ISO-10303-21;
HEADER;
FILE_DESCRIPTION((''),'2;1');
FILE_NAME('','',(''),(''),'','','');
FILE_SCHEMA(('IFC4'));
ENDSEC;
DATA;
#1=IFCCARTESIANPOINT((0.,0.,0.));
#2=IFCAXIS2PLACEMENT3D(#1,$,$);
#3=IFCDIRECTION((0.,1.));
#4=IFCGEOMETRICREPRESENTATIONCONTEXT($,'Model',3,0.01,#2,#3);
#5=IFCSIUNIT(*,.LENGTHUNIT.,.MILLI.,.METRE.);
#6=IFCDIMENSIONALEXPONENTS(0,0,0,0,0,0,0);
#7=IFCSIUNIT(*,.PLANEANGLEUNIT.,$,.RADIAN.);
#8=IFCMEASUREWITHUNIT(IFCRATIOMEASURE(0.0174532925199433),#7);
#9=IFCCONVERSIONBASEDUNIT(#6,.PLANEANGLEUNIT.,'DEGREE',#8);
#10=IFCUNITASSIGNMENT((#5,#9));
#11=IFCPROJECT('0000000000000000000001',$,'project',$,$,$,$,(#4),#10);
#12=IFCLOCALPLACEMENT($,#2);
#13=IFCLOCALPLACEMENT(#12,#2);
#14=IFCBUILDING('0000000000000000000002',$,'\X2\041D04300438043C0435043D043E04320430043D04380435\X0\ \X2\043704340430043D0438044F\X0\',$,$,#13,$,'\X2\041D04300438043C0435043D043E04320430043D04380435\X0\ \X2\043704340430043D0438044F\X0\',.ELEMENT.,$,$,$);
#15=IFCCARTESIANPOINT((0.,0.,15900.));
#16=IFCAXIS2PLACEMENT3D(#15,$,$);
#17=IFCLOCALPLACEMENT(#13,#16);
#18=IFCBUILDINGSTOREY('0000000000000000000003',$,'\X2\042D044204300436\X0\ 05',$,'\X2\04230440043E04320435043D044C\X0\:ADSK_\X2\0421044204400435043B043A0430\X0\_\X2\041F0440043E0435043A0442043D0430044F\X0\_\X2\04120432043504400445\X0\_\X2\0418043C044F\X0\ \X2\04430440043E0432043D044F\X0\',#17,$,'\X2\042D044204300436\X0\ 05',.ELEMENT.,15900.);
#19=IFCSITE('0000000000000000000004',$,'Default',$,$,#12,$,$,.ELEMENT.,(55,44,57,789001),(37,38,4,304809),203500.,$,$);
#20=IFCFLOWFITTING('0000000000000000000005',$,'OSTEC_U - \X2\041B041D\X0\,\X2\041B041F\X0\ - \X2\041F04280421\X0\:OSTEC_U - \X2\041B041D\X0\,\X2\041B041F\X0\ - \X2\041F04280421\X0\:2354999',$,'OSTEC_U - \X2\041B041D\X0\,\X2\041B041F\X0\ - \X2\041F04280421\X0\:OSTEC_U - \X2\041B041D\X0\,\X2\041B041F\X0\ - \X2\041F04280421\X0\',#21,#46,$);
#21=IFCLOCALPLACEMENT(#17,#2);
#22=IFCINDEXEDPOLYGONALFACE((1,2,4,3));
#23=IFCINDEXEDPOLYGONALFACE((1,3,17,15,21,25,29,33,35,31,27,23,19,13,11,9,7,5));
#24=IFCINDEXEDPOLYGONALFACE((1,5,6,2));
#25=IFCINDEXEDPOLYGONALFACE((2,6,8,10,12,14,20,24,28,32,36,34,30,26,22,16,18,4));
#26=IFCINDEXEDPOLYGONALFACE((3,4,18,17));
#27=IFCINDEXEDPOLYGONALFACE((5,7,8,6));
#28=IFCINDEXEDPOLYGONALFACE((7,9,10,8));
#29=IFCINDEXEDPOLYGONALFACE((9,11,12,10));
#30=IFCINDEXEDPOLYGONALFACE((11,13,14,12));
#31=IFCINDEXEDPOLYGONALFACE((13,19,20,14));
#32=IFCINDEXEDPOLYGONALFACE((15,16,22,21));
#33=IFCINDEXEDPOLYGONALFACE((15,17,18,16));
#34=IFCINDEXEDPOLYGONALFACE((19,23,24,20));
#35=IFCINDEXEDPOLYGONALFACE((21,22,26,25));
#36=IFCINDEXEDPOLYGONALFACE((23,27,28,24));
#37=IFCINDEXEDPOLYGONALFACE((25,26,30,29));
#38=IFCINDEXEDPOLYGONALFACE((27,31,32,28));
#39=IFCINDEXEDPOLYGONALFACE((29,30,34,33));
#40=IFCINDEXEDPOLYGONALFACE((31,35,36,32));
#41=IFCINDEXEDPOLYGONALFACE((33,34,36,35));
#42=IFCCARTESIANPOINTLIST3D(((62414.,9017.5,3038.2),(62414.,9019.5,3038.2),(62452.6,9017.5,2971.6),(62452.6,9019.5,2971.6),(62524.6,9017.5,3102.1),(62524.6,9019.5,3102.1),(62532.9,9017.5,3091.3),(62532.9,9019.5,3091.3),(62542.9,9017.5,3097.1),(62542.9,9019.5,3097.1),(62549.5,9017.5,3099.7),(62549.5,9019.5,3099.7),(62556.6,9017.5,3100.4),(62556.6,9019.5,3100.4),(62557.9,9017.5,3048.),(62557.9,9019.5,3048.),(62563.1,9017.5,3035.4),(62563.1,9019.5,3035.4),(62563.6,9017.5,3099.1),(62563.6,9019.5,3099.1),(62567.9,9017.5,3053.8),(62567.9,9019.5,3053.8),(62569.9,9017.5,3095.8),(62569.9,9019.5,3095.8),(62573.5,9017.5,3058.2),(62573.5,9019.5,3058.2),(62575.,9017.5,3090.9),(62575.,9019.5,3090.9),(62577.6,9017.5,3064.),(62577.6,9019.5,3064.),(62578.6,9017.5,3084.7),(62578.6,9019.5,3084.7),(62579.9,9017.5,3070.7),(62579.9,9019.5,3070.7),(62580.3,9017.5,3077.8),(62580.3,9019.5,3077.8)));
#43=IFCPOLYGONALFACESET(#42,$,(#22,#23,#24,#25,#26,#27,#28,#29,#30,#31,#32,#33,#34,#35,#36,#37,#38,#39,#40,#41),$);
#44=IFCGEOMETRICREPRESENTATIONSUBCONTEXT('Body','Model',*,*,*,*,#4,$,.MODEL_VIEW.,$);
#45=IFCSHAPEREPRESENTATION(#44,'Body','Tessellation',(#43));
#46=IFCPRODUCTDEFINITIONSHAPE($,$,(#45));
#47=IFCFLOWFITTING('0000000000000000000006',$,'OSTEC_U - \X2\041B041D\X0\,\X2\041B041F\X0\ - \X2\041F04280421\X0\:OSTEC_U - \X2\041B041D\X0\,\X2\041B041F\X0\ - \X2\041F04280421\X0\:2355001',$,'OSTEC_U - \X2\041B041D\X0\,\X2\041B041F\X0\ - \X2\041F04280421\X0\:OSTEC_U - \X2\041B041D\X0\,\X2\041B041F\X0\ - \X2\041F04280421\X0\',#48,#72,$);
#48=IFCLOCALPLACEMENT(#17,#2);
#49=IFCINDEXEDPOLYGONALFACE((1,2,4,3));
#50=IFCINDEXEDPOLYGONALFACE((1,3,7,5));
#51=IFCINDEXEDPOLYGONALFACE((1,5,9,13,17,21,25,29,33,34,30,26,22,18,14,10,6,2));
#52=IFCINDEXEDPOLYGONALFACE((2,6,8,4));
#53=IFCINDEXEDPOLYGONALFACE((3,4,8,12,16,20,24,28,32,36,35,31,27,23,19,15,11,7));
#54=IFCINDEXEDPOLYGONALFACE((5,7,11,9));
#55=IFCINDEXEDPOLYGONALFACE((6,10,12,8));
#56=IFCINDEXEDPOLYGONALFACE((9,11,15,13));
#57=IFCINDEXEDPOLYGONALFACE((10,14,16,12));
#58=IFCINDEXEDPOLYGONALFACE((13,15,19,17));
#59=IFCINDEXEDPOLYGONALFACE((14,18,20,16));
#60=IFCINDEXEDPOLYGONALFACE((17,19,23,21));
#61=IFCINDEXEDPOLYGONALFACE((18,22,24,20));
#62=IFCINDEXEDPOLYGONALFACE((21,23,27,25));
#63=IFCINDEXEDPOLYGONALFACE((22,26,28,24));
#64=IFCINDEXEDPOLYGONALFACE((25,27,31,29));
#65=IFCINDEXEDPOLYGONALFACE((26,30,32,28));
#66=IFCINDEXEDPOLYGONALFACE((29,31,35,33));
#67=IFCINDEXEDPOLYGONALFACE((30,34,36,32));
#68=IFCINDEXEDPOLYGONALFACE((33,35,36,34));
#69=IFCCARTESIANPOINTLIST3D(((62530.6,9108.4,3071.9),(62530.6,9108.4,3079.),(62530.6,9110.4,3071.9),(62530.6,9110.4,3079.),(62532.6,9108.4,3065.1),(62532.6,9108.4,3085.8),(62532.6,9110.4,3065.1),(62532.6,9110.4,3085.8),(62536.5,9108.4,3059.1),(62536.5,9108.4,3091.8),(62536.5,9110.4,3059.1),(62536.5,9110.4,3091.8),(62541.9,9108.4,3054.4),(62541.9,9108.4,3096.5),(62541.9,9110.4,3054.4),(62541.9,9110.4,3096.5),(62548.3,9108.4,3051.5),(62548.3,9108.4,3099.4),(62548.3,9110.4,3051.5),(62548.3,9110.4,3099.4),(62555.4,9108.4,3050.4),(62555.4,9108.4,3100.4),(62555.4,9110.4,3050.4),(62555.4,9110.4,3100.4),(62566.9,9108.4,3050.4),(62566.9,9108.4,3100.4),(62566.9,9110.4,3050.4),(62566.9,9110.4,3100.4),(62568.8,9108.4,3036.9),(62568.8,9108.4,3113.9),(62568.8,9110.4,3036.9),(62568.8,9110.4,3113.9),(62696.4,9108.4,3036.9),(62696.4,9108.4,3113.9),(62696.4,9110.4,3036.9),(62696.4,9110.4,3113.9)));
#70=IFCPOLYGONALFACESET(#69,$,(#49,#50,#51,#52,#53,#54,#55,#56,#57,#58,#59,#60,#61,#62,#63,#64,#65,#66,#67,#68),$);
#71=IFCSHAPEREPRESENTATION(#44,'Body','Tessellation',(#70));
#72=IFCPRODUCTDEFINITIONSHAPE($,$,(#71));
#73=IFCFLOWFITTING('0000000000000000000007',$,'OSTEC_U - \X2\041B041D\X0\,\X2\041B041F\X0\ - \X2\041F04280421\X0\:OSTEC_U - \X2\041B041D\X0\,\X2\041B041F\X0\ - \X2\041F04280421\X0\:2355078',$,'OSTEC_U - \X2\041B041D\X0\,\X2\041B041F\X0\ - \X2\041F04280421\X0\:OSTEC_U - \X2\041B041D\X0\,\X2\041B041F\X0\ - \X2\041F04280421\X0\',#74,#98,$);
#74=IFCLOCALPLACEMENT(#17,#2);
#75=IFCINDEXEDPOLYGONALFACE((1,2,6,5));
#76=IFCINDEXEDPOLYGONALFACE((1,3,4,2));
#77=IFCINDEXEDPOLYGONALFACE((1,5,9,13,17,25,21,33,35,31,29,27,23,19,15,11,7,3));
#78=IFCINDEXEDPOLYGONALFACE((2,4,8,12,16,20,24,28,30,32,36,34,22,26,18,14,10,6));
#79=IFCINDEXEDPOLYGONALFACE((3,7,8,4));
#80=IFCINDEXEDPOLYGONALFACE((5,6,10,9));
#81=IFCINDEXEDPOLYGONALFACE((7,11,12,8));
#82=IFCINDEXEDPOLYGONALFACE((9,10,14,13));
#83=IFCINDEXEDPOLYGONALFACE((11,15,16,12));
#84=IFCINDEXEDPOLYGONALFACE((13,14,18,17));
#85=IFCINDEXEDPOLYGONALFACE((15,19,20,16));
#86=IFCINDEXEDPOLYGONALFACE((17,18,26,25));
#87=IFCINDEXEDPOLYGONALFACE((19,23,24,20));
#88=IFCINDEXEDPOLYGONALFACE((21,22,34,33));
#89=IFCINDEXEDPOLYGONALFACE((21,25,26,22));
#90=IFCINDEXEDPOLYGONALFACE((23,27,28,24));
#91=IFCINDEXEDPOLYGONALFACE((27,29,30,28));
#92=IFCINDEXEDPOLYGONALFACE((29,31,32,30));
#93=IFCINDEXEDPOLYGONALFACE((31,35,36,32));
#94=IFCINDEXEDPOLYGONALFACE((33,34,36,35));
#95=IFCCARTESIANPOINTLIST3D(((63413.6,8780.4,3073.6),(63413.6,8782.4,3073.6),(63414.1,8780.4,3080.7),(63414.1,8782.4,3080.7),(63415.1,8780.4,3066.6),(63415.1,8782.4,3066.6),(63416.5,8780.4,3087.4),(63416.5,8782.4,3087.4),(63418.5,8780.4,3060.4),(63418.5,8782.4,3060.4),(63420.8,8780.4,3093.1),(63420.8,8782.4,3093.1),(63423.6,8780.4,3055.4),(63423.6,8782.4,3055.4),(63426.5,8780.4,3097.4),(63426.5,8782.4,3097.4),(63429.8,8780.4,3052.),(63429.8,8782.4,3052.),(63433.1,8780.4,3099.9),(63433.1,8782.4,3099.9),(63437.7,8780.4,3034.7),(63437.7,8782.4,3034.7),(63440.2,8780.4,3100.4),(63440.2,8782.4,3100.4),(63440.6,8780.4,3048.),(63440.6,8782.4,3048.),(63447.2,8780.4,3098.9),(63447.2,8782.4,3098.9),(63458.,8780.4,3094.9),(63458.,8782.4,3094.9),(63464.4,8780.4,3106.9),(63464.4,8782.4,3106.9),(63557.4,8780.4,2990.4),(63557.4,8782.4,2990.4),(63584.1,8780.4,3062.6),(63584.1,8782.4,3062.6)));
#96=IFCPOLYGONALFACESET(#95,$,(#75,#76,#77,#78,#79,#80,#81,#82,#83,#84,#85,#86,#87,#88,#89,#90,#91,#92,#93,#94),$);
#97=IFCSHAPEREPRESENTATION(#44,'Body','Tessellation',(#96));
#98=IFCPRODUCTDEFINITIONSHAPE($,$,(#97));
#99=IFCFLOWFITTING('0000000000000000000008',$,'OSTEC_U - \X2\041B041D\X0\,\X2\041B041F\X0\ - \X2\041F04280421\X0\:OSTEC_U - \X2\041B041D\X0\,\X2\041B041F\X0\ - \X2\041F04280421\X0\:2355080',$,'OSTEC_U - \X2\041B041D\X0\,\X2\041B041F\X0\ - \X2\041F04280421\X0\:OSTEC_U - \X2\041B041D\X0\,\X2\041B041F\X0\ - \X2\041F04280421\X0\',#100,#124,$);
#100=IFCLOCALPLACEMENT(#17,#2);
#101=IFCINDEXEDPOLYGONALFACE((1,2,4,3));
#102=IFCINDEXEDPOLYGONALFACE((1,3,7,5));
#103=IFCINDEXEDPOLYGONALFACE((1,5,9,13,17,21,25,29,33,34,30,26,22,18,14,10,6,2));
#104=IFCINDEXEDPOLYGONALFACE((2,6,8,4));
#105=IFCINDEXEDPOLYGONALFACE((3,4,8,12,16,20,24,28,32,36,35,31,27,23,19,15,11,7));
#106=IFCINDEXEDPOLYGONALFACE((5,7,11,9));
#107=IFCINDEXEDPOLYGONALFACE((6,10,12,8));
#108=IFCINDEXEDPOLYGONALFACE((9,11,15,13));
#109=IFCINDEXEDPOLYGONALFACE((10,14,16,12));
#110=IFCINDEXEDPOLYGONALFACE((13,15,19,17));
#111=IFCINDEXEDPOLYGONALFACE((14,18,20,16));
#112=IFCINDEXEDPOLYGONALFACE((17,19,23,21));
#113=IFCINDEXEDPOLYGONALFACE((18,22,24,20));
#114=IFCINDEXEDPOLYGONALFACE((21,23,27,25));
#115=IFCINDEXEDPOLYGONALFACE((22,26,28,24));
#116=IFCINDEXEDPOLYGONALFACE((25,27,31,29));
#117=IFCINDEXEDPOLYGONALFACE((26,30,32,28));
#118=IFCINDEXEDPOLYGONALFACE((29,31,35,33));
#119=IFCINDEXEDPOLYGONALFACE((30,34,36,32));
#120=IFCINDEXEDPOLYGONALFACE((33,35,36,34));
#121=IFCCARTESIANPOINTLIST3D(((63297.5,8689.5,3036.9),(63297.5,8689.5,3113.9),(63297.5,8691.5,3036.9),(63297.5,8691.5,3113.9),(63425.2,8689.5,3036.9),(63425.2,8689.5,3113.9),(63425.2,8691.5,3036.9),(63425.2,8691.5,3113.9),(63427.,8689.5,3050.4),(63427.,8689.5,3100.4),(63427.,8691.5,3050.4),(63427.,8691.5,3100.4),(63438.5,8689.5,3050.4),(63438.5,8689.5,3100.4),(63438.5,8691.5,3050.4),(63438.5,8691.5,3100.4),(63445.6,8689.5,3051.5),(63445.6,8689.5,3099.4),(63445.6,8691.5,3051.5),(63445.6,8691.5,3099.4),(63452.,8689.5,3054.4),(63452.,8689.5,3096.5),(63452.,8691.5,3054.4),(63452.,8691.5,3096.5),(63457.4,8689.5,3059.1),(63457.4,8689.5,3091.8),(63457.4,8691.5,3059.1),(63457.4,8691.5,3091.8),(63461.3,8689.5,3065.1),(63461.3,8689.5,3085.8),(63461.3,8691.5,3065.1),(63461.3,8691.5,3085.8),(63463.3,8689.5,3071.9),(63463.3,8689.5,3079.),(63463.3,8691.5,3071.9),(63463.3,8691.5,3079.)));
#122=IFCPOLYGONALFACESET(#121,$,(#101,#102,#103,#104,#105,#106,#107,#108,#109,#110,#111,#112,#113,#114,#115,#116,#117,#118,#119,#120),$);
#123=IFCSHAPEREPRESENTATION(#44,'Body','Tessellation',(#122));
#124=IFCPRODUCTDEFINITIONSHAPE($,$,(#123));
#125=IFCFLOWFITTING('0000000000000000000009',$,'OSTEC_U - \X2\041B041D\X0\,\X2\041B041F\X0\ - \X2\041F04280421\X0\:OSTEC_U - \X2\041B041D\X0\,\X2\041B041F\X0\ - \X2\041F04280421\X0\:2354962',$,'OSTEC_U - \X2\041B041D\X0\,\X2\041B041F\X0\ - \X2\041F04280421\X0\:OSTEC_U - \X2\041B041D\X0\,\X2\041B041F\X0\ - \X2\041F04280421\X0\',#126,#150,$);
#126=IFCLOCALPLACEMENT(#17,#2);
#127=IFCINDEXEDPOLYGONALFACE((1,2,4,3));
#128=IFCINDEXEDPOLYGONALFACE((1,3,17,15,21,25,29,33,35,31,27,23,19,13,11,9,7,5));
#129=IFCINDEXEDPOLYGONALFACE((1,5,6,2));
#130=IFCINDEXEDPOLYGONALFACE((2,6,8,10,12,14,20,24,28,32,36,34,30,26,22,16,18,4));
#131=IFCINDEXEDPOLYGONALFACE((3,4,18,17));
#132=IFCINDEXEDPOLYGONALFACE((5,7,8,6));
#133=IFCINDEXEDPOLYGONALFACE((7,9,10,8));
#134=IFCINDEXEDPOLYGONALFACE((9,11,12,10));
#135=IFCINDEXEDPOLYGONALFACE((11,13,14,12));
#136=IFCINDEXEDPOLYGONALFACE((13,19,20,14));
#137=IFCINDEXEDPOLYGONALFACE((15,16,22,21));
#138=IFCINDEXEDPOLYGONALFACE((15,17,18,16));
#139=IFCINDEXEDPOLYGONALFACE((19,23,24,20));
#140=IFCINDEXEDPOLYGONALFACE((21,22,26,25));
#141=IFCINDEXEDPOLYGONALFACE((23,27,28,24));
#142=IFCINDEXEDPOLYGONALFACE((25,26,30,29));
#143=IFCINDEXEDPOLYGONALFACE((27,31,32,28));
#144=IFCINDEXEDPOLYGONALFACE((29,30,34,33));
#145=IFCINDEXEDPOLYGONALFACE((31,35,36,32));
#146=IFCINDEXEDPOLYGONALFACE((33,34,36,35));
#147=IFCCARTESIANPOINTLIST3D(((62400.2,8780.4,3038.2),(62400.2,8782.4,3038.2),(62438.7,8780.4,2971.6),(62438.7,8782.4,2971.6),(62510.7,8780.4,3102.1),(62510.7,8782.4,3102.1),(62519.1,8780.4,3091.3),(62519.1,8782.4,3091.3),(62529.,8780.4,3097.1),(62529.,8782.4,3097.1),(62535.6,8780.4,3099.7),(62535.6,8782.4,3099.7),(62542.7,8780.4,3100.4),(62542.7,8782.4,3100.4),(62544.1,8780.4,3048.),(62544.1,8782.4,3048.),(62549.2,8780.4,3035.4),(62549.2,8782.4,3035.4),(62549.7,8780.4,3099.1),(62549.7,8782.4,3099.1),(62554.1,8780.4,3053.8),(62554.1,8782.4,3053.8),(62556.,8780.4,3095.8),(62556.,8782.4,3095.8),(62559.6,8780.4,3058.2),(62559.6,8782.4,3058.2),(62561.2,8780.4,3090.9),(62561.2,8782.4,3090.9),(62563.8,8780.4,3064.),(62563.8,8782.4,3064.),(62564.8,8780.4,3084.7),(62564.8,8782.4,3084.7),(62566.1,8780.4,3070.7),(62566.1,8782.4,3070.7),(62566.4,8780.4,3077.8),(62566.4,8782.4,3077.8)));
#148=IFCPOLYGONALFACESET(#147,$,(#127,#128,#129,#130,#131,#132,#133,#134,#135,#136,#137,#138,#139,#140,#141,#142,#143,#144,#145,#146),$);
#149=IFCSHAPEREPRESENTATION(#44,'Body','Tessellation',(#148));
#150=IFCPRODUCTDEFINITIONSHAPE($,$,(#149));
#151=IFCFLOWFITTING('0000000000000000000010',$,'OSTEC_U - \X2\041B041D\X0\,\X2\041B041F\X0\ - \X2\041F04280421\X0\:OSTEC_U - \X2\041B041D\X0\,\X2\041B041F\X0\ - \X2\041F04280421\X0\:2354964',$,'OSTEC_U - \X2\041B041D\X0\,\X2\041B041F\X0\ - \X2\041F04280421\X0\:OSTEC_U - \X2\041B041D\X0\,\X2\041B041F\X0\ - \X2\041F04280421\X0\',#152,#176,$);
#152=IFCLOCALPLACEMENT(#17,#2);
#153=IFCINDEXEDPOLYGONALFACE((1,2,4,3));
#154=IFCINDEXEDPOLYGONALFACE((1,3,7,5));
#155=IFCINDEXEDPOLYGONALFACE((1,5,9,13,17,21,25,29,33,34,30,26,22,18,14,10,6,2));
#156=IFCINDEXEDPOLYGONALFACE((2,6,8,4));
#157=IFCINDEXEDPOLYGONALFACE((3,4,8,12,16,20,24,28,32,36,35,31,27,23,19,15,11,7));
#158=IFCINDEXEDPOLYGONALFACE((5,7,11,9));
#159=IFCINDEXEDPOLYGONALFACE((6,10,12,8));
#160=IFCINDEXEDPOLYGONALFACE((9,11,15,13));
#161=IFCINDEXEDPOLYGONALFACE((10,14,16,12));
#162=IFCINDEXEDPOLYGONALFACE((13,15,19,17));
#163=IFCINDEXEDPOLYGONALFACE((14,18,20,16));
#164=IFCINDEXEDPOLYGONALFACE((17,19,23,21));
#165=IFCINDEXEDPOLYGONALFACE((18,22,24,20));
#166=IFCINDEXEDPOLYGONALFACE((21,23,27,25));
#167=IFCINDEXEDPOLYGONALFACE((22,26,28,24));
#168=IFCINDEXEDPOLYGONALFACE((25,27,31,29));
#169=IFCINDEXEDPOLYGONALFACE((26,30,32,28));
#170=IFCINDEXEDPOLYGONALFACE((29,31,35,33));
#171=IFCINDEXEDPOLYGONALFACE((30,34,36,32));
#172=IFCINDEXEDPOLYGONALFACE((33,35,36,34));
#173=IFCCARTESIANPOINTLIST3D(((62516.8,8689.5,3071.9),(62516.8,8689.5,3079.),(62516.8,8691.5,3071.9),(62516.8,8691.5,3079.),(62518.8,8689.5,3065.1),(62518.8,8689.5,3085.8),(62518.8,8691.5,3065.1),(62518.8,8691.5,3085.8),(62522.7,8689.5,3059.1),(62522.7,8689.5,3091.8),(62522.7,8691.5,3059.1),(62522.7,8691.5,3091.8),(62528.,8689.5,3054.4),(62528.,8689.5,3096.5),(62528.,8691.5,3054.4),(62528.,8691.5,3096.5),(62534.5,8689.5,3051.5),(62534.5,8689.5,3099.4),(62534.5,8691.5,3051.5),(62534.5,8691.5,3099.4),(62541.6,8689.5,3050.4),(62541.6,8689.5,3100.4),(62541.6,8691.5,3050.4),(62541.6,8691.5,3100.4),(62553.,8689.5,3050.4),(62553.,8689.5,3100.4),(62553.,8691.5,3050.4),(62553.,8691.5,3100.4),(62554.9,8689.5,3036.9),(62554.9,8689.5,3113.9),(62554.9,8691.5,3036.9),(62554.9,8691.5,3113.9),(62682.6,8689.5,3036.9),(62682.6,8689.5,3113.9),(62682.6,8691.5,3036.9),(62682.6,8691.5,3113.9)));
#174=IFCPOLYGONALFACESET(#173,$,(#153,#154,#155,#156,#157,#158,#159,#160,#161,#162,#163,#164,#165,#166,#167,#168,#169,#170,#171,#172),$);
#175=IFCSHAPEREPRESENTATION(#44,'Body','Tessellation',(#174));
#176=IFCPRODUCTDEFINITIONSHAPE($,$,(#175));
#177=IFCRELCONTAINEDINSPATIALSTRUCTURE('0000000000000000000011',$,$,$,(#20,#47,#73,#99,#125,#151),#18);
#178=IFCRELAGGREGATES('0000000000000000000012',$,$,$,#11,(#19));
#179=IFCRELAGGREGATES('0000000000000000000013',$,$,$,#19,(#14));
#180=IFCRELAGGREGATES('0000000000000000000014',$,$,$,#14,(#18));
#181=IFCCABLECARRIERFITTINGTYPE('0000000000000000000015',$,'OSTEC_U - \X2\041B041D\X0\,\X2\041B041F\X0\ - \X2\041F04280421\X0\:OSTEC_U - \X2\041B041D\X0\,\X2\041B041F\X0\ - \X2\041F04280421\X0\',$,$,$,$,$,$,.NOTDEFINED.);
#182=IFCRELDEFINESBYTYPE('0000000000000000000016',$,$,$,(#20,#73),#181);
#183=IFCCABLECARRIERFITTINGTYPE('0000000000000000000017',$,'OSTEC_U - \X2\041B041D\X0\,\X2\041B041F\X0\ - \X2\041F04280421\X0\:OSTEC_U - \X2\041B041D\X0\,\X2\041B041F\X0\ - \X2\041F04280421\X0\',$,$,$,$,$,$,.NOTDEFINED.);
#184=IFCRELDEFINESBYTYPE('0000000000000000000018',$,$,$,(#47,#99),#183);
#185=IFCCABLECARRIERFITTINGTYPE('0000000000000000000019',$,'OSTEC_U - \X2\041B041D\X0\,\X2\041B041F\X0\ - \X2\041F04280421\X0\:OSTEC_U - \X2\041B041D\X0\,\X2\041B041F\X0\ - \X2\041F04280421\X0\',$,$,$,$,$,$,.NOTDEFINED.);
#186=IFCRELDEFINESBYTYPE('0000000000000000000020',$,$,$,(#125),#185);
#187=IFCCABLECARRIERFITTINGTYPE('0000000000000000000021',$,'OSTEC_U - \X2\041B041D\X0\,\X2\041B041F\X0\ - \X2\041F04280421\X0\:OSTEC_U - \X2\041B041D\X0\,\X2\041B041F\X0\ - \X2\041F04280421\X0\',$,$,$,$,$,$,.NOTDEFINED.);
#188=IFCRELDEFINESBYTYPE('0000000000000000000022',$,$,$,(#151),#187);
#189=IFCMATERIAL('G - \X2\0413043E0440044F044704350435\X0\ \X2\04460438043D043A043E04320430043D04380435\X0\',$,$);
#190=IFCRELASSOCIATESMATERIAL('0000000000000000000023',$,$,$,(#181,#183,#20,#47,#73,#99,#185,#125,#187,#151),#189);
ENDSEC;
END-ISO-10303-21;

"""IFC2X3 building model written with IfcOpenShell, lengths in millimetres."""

from ifc_helpers import new_model, entity, si_unit, converted_unit, direction, frame, frame_2d, origin, place, context, subcontext, project, spatial, polyline, circle_curve, parameter, trimmed, segment, composite_curve, outline, extrude, source, transform, mapped, material, type_object, type_shapes, element, save


model = new_model("IFC2X3")

# Units and contexts
model_context = context("Model", 3, precision=0.01, world=origin(), true_north=direction((0.0, 1.0)))
body_context = subcontext(model_context, "Body", "Model", "MODEL_VIEW")
ifc_project = project(units=[si_unit("LENGTHUNIT", "METRE", prefix="MILLI"), converted_unit("PLANEANGLEUNIT", "DEGREE", entity("IfcRatioMeasure", 0.0174532925199433), si_unit("PLANEANGLEUNIT", "RADIAN"), dimensions=[0, 0, 0, 0, 0, 0, 0])], contexts=[model_context])

# Site, building, storey
site_placement = place(None, origin())
site = spatial("IfcSite", under=ifc_project, at=site_placement, Name="Default", CompositionType="ELEMENT", RefLatitude=(55, 44, 57, 789001), RefLongitude=(37, 38, 4, 304809), RefElevation=203500.0)
building_placement = place(site_placement, origin())
building = spatial("IfcBuilding", under=site, at=building_placement, Name="Наименование здания", LongName="Наименование здания", CompositionType="ELEMENT")
storey_placement = place(building_placement, frame((0.0, 0.0, 15900.0)))
storey = spatial("IfcBuildingStorey", under=building, at=storey_placement, Name="Этаж 05", ObjectType="Уровень:ADSK_Стрелка_Проектная_Вверх_Имя уровня", LongName="Этаж 05", CompositionType="ELEMENT", Elevation=15900.0)

# Flow fittings
ifc_material_1 = material(Name="G - Горячее цинкование")
cable_carrier_fitting_type_1 = type_object("IfcCableCarrierFittingType", Name="OSTEC_U - ЛН,ЛП - ПШС:OSTEC_U - ЛН,ЛП - ПШС", PredefinedType="NOTDEFINED", material=ifc_material_1)
shared_shape_1 = source(origin(), body_context, "Body", "SweptSolid", [
    extrude(outline(composite_curve([segment(trimmed(circle_curve(frame_2d((-41.5, 0.0), x_axis=(1.0, 0.0)), 25.0), [parameter(90.0)], [parameter(270.0)], True, "PARAMETER"), True, "CONTINUOUS"), segment(polyline([(-41.5, -25.0), (-30.0, -25.0)]), True, "CONTINUOUS"), segment(polyline([(-30.0, -25.0), (-28.1, -38.5)]), True, "CONTINUOUS"), segment(polyline([(-28.1, -38.5), (99.5, -38.5)]), True, "CONTINUOUS"), segment(polyline([(99.5, -38.5), (99.5, 38.5)]), True, "CONTINUOUS"), segment(polyline([(99.5, 38.5), (-28.1, 38.5)]), True, "CONTINUOUS"), segment(polyline([(-28.1, 38.5), (-30.0, 25.0)]), True, "CONTINUOUS"), segment(polyline([(-30.0, 25.0), (-41.5, 25.0)]), True, "CONTINUOUS")], self_intersect=False)), frame((41.5, 0.0, 0.0), z_axis=(0.0, 0.0, -1.0), x_axis=(1.0, 0.0, 0.0)), (0.0, 0.0, -1.0), 2.0),
])
type_shapes(cable_carrier_fitting_type_1, [shared_shape_1])
cable_carrier_fitting_type_2 = type_object("IfcCableCarrierFittingType", Name="OSTEC_U - ЛН,ЛП - ПШС:OSTEC_U - ЛН,ЛП - ПШС", PredefinedType="NOTDEFINED", material=ifc_material_1)
type_shapes(cable_carrier_fitting_type_2, [shared_shape_1])
flow_fitting_1_placement = place(storey_placement, frame((62555.4, 9019.5, 3075.4), z_axis=(0.0, -1.0, 0.0), x_axis=(-0.865893, 0.0, -0.500229)))
element("IfcFlowFitting", 1, at=flow_fitting_1_placement, inside=storey, type_object=cable_carrier_fitting_type_1, material=ifc_material_1, Name="OSTEC_U - ЛН,ЛП - ПШС:OSTEC_U - ЛН,ЛП - ПШС:2354999", ObjectType="OSTEC_U - ЛН,ЛП - ПШС:OSTEC_U - ЛН,ЛП - ПШС", context=body_context, shape_type="MappedRepresentation", body=[
    mapped(shared_shape_1, transform((0.0, 0.0, 0.0), scale=1.0)),
])
flow_fitting_2_placement = place(storey_placement, frame((62555.4, 9108.4, 3075.4), z_axis=(0.0, 1.0, 0.0), x_axis=(1.0, 0.0, 0.0)))
element("IfcFlowFitting", 2, at=flow_fitting_2_placement, inside=storey, type_object=cable_carrier_fitting_type_2, material=ifc_material_1, Name="OSTEC_U - ЛН,ЛП - ПШС:OSTEC_U - ЛН,ЛП - ПШС:2355001", ObjectType="OSTEC_U - ЛН,ЛП - ПШС:OSTEC_U - ЛН,ЛП - ПШС", context=body_context, shape_type="MappedRepresentation", body=[
    mapped(shared_shape_1, transform((0.0, 0.0, 0.0), scale=1.0)),
])
flow_fitting_3_placement = place(storey_placement, frame((63438.5, 8780.4, 3075.4), z_axis=(0.0, 1.0, 0.0), x_axis=(0.937802, 0.0, -0.347171)))
element("IfcFlowFitting", 3, at=flow_fitting_3_placement, inside=storey, type_object=cable_carrier_fitting_type_1, material=ifc_material_1, Name="OSTEC_U - ЛН,ЛП - ПШС:OSTEC_U - ЛН,ЛП - ПШС:2355078", ObjectType="OSTEC_U - ЛН,ЛП - ПШС:OSTEC_U - ЛН,ЛП - ПШС", context=body_context, shape_type="MappedRepresentation", body=[
    mapped(shared_shape_1, transform((0.0, 0.0, 0.0), scale=1.0)),
])
flow_fitting_4_placement = place(storey_placement, frame((63438.5, 8691.5, 3075.4), z_axis=(0.0, -1.0, 0.0), x_axis=(-1.0, 0.0, 0.0)))
element("IfcFlowFitting", 4, at=flow_fitting_4_placement, inside=storey, type_object=cable_carrier_fitting_type_2, material=ifc_material_1, Name="OSTEC_U - ЛН,ЛП - ПШС:OSTEC_U - ЛН,ЛП - ПШС:2355080", ObjectType="OSTEC_U - ЛН,ЛП - ПШС:OSTEC_U - ЛН,ЛП - ПШС", context=body_context, shape_type="MappedRepresentation", body=[
    mapped(shared_shape_1, transform((0.0, 0.0, 0.0), scale=1.0)),
])
cable_carrier_fitting_type_3 = type_object("IfcCableCarrierFittingType", Name="OSTEC_U - ЛН,ЛП - ПШС:OSTEC_U - ЛН,ЛП - ПШС", PredefinedType="NOTDEFINED", material=ifc_material_1)
shared_shape_2 = source(origin(), body_context, "Body", "SweptSolid", [
    extrude(outline(composite_curve([segment(trimmed(circle_curve(frame_2d((-41.5, 0.0), x_axis=(1.0, 0.0)), 25.0), [parameter(90.0)], [parameter(270.0)], True, "PARAMETER"), True, "CONTINUOUS"), segment(polyline([(-41.5, -25.0), (-30.0, -25.0)]), True, "CONTINUOUS"), segment(polyline([(-30.0, -25.0), (-28.1, -38.5)]), True, "CONTINUOUS"), segment(polyline([(-28.1, -38.5), (99.5, -38.5)]), True, "CONTINUOUS"), segment(polyline([(99.5, -38.5), (99.5, 38.5)]), True, "CONTINUOUS"), segment(polyline([(99.5, 38.5), (-28.1, 38.5)]), True, "CONTINUOUS"), segment(polyline([(-28.1, 38.5), (-30.0, 25.0)]), True, "CONTINUOUS"), segment(polyline([(-30.0, 25.0), (-41.5, 25.0)]), True, "CONTINUOUS")], self_intersect=False)), frame((41.5, 0.0, 0.0)), (0.0, 0.0, 1.0), 2.0),
])
type_shapes(cable_carrier_fitting_type_3, [shared_shape_2])
flow_fitting_5_placement = place(storey_placement, frame((62541.6, 8780.4, 3075.4), z_axis=(0.0, 1.0, 0.0), x_axis=(-0.865893, 0.0, -0.500229)))
element("IfcFlowFitting", 5, at=flow_fitting_5_placement, inside=storey, type_object=cable_carrier_fitting_type_3, material=ifc_material_1, Name="OSTEC_U - ЛН,ЛП - ПШС:OSTEC_U - ЛН,ЛП - ПШС:2354962", ObjectType="OSTEC_U - ЛН,ЛП - ПШС:OSTEC_U - ЛН,ЛП - ПШС", context=body_context, shape_type="MappedRepresentation", body=[
    mapped(shared_shape_2, transform((0.0, 0.0, 0.0), scale=1.0)),
])
cable_carrier_fitting_type_4 = type_object("IfcCableCarrierFittingType", Name="OSTEC_U - ЛН,ЛП - ПШС:OSTEC_U - ЛН,ЛП - ПШС", PredefinedType="NOTDEFINED", material=ifc_material_1)
type_shapes(cable_carrier_fitting_type_4, [shared_shape_2])
flow_fitting_6_placement = place(storey_placement, frame((62541.6, 8691.5, 3075.4), z_axis=(0.0, -1.0, 0.0), x_axis=(1.0, 0.0, 0.0)))
element("IfcFlowFitting", 6, at=flow_fitting_6_placement, inside=storey, type_object=cable_carrier_fitting_type_4, material=ifc_material_1, Name="OSTEC_U - ЛН,ЛП - ПШС:OSTEC_U - ЛН,ЛП - ПШС:2354964", ObjectType="OSTEC_U - ЛН,ЛП - ПШС:OSTEC_U - ЛН,ЛП - ПШС", context=body_context, shape_type="MappedRepresentation", body=[
    mapped(shared_shape_2, transform((0.0, 0.0, 0.0), scale=1.0)),
])

save(model, "model.ifc")
